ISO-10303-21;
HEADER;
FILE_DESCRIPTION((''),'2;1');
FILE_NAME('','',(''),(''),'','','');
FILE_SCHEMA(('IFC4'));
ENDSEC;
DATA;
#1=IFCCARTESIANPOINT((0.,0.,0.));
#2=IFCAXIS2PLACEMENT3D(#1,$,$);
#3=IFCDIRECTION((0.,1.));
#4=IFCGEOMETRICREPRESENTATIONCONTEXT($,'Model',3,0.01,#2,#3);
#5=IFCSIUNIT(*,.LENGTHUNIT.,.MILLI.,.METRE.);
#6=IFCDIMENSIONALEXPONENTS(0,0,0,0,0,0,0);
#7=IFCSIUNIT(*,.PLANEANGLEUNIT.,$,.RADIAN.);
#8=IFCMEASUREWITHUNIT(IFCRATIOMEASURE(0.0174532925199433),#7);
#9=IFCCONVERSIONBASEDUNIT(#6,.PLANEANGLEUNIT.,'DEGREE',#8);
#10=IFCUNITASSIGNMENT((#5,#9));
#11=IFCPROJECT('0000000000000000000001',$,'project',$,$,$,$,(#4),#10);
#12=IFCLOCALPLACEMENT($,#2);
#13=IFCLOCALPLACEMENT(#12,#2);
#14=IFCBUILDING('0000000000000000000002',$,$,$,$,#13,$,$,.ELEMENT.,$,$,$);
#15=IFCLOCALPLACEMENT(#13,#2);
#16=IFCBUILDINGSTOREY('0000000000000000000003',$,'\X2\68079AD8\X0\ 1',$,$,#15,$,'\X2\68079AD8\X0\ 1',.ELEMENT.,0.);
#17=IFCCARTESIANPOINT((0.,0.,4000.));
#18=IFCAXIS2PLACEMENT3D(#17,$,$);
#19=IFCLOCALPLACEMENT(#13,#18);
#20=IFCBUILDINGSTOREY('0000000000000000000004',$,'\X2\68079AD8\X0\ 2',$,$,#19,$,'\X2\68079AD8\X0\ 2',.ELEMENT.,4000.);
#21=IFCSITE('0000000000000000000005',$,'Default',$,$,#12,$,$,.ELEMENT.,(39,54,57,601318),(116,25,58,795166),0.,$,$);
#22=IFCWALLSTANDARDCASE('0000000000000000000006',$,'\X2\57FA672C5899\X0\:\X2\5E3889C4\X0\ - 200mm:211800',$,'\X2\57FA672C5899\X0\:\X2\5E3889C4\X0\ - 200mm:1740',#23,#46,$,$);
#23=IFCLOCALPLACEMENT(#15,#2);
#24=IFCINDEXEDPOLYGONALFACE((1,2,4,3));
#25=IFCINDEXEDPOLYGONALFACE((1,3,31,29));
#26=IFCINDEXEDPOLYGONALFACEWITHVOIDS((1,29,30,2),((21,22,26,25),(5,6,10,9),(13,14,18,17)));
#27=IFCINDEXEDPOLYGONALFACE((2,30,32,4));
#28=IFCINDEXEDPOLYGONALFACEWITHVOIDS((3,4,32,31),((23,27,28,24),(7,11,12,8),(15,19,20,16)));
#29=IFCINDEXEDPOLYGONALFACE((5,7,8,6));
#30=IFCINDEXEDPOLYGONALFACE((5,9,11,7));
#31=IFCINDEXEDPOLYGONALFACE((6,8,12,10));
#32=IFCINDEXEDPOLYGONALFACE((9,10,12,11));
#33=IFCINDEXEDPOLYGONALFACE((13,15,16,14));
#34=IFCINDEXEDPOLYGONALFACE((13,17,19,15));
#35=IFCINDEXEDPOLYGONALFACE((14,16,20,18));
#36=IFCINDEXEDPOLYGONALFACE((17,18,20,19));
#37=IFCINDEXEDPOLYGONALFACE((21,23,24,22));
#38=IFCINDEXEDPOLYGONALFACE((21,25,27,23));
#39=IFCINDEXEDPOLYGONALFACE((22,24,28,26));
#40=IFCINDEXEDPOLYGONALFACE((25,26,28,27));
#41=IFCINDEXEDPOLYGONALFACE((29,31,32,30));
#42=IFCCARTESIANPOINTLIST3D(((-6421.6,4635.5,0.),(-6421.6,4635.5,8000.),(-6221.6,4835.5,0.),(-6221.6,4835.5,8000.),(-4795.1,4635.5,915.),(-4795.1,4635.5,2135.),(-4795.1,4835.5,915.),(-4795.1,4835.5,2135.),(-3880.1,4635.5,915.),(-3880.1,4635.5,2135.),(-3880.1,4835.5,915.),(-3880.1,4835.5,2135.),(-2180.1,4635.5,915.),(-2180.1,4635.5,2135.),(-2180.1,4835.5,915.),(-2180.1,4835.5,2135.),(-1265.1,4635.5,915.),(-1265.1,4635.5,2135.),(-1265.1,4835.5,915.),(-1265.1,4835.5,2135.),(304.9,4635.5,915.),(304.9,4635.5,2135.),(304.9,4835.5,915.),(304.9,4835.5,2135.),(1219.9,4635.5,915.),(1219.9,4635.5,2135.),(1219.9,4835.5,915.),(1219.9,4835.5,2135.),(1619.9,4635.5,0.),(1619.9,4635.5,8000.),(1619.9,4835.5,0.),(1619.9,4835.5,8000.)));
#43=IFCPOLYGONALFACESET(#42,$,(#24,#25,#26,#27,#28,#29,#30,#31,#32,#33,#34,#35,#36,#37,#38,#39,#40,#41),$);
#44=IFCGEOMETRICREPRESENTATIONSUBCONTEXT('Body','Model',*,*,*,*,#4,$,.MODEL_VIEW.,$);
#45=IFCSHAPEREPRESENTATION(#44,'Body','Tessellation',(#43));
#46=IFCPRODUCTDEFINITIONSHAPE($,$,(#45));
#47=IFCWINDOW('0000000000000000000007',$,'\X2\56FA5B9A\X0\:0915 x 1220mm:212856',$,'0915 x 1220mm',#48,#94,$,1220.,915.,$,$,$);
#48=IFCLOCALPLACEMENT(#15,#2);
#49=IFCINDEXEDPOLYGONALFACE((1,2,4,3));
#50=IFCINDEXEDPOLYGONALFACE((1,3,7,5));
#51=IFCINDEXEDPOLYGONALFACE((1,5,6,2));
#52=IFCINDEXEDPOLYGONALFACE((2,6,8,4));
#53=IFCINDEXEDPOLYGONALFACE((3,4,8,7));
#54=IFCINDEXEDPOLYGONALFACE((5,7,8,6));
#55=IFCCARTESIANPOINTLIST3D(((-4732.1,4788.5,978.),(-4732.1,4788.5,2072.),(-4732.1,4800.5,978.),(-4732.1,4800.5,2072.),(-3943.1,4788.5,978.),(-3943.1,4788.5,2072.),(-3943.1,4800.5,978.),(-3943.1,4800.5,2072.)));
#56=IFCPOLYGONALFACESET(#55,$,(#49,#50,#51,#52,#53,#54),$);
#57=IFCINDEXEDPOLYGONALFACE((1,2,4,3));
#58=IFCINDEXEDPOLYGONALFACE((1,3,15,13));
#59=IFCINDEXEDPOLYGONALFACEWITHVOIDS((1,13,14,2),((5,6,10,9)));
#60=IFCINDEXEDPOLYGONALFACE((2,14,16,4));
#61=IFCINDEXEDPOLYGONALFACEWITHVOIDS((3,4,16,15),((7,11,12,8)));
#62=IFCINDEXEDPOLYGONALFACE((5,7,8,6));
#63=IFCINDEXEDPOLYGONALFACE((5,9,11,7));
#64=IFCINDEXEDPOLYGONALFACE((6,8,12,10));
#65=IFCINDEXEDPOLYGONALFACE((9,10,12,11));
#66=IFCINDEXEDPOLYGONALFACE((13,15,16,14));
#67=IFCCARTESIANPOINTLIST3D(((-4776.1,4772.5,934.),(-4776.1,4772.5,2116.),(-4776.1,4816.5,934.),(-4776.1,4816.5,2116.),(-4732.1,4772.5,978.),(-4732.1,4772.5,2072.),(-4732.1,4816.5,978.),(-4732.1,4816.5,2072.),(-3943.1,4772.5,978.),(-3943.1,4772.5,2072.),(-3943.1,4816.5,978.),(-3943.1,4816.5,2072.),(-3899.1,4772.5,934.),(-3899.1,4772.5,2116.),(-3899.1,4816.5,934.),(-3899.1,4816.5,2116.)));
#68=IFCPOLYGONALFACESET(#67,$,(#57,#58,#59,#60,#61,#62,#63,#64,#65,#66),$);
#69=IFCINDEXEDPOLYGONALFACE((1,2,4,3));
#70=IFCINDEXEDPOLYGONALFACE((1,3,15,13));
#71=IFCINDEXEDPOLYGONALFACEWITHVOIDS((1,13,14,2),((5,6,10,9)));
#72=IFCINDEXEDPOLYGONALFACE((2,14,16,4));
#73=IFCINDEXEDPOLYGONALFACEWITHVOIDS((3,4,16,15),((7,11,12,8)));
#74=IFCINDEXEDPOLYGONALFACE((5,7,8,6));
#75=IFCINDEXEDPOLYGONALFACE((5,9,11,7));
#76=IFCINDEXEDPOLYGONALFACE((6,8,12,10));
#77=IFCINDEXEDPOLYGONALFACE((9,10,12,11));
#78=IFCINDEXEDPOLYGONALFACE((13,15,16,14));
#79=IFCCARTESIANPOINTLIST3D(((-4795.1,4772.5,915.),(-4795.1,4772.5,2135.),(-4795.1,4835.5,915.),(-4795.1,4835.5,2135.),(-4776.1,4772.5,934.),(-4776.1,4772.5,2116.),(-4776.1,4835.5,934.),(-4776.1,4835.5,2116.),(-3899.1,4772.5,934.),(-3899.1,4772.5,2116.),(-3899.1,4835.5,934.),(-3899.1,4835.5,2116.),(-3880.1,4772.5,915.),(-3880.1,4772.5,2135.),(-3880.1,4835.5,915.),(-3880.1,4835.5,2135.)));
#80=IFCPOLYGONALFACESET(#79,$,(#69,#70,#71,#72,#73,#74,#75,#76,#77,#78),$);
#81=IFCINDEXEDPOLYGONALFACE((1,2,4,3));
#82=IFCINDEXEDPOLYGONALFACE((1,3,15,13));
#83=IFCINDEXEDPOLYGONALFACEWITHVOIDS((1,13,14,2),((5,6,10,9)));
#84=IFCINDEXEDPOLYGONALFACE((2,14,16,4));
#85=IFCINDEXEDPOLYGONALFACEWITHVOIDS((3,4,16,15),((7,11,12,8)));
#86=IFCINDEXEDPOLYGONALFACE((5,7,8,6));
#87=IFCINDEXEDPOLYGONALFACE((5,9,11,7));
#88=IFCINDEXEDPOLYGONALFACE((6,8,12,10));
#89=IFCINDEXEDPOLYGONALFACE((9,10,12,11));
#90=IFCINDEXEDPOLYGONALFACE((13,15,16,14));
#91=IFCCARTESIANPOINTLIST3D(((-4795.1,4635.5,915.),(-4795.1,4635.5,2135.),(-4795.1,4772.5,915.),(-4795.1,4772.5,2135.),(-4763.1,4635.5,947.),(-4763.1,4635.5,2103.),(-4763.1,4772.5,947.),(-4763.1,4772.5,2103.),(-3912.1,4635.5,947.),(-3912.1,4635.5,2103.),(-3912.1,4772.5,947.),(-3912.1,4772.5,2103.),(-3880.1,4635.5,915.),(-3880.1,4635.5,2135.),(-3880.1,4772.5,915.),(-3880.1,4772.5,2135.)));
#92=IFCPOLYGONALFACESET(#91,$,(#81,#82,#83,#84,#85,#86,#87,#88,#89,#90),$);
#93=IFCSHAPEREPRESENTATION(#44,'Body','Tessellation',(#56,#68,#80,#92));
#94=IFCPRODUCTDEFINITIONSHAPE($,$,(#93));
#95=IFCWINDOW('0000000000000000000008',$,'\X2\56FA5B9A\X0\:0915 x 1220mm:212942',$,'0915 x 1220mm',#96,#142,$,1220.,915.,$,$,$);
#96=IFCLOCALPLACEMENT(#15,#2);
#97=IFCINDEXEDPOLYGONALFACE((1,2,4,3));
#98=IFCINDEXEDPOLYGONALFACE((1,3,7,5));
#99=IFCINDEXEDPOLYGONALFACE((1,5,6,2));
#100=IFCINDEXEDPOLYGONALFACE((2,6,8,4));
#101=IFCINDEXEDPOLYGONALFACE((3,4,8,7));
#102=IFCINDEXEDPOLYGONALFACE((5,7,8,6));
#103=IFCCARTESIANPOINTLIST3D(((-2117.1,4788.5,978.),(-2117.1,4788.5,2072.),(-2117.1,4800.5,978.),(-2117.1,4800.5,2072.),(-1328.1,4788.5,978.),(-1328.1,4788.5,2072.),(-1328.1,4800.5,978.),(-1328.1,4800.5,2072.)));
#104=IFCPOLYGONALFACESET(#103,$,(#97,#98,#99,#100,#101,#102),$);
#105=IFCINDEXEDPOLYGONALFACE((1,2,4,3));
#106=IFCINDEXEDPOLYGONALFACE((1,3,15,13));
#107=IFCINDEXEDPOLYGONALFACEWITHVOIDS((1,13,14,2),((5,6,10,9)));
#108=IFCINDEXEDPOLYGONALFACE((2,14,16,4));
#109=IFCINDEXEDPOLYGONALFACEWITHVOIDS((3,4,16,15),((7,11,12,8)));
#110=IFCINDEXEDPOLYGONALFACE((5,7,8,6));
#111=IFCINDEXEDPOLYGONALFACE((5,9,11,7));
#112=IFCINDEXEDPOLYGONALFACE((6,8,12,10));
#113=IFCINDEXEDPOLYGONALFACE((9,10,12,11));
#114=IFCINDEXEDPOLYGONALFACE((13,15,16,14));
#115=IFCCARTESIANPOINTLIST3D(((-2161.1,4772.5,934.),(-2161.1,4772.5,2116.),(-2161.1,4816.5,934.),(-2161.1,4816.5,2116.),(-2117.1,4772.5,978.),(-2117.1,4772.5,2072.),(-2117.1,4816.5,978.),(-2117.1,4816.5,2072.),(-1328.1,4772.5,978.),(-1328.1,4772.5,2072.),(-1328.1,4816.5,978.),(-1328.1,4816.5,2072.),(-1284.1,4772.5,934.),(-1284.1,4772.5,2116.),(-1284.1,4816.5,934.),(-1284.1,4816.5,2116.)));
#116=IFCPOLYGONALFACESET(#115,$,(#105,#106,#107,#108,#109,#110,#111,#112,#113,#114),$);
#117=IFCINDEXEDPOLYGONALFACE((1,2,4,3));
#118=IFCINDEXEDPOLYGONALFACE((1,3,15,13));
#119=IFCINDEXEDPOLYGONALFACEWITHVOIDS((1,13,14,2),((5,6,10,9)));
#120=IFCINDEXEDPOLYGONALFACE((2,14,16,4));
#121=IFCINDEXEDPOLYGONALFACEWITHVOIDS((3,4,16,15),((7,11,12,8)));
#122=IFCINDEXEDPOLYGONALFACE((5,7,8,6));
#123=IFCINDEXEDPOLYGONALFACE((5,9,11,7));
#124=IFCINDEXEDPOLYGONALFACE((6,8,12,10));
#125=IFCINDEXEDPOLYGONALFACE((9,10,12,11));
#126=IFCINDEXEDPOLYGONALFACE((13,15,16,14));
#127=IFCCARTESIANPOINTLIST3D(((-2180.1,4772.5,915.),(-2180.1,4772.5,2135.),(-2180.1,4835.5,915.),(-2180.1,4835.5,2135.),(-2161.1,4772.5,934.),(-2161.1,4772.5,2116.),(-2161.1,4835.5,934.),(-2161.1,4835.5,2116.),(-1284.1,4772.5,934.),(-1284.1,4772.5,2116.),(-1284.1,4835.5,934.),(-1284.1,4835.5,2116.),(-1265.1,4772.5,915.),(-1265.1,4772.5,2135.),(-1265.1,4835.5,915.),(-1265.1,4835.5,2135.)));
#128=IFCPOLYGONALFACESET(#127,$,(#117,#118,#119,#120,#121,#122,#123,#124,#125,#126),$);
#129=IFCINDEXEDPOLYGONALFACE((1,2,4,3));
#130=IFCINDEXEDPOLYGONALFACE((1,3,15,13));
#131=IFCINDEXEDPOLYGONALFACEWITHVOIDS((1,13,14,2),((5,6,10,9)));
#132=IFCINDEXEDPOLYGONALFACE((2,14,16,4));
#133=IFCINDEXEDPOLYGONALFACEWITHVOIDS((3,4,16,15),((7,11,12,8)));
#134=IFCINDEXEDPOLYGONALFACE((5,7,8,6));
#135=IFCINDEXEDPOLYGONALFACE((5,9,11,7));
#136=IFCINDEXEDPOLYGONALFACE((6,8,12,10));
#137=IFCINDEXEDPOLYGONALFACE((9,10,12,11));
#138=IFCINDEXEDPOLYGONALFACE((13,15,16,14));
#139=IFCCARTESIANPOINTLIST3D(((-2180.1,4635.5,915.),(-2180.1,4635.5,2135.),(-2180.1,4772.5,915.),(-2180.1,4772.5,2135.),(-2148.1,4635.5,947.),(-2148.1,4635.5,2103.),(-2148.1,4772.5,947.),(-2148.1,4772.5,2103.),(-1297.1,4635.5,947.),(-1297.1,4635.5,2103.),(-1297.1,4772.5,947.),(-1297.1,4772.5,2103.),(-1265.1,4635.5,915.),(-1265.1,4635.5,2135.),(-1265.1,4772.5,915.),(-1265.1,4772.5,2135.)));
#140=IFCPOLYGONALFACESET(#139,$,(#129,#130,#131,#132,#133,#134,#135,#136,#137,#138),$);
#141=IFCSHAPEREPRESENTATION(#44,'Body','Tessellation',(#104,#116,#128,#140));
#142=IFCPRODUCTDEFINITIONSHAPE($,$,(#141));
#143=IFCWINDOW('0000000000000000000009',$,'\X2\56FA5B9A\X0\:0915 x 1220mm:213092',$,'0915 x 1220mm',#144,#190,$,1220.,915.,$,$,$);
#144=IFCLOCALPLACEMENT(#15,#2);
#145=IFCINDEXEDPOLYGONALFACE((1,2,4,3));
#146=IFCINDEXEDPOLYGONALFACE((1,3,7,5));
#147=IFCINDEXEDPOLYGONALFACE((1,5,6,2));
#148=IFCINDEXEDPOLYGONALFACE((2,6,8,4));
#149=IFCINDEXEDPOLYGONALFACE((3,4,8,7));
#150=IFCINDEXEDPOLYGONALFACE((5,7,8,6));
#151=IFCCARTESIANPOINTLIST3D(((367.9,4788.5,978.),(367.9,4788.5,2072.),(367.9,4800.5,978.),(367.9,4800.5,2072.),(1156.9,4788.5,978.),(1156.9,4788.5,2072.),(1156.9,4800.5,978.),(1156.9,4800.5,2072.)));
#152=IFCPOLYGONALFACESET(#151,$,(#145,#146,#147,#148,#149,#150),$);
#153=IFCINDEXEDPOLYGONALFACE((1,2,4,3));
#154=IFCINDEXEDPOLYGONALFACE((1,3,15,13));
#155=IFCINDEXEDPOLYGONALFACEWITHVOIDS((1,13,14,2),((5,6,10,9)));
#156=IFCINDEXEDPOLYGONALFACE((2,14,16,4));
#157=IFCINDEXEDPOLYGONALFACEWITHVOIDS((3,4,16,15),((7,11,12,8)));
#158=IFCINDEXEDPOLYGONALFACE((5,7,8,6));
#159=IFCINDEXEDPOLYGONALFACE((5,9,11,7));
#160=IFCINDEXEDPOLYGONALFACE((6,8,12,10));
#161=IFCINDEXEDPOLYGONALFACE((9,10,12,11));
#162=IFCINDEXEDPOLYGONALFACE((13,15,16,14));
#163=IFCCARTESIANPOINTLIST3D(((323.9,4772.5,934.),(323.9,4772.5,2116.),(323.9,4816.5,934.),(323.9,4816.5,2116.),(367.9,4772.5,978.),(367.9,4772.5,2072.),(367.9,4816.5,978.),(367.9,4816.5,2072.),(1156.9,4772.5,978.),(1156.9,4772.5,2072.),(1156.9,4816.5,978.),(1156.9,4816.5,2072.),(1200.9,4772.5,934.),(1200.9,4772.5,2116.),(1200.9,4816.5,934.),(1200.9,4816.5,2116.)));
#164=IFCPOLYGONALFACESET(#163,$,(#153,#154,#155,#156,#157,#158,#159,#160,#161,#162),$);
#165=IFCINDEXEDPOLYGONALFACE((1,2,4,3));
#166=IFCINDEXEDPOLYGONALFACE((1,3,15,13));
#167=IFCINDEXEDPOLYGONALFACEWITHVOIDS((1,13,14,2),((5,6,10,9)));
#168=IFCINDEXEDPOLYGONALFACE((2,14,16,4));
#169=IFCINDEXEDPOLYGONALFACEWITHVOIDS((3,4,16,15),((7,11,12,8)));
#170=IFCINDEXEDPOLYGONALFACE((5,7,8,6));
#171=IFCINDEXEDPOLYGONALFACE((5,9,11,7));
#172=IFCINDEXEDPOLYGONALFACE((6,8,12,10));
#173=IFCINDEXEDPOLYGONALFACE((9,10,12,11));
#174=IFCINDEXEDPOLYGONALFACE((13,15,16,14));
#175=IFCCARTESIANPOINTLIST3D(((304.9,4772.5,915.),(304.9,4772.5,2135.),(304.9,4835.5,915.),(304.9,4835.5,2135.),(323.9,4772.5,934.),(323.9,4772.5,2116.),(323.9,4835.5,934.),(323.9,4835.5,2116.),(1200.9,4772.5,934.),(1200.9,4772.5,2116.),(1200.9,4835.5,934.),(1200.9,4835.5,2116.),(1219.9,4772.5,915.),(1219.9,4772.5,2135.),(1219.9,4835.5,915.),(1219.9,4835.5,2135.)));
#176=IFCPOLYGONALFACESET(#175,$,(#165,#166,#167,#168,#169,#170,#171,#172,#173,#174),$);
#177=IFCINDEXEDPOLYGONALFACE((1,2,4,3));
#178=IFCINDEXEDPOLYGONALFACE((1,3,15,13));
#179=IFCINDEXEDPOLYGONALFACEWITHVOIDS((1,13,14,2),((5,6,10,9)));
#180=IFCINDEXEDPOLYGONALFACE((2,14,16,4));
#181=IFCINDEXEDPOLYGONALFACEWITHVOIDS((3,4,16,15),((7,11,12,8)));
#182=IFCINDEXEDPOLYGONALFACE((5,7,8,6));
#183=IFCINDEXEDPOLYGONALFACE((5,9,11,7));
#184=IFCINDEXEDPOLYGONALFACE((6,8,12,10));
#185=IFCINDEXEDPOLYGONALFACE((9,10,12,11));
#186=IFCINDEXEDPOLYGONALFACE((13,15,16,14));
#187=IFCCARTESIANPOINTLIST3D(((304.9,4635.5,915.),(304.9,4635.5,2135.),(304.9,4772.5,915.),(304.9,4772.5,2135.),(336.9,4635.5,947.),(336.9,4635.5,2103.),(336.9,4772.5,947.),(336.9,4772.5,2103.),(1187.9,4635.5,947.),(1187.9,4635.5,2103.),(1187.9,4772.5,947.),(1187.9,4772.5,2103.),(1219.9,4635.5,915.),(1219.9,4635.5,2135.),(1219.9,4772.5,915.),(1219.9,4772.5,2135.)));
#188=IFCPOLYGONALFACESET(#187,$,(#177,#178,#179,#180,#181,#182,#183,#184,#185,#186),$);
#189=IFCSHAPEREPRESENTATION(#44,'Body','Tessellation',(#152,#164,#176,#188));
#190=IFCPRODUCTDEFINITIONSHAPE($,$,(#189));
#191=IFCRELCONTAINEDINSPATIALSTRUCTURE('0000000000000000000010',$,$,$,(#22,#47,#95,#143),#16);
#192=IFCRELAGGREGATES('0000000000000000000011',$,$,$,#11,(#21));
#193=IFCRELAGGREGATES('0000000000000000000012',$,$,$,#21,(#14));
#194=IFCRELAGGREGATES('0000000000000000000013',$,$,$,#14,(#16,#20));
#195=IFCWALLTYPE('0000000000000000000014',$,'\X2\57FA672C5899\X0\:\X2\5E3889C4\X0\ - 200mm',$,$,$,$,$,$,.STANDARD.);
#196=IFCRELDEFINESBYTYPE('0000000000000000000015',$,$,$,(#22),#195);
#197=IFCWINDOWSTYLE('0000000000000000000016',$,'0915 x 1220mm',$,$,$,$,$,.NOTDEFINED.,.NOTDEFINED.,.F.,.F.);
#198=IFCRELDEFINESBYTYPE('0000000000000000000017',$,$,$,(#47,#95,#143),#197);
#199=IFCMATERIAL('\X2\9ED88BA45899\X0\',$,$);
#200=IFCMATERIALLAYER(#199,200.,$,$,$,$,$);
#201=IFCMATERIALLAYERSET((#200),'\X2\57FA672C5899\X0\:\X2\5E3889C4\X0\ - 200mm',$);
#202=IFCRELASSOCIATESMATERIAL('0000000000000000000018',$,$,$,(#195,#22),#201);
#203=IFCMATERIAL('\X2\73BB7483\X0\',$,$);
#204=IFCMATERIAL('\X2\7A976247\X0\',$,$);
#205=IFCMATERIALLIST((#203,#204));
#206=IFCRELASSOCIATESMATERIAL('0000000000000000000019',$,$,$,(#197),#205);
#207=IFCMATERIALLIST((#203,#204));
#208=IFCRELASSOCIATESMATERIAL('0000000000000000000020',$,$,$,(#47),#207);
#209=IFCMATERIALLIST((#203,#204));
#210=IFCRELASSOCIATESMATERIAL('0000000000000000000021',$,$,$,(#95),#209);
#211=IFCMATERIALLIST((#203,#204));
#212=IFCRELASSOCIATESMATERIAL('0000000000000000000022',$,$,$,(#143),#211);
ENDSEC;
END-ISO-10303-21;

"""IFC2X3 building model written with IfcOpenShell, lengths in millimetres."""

from ifc_helpers import new_model, entity, si_unit, converted_unit, direction, frame, frame_2d, origin, place, context, subcontext, project, spatial, polyline, rectangle, outline, extrude, source, transform, mapped, material, material_list, layer, layer_set, layer_usage, type_object, type_shapes, element, fill, save


model = new_model("IFC2X3")

# Units and contexts
model_context = context("Model", 3, precision=0.01, world=origin(), true_north=direction((0.0, 1.0)))
body_context = subcontext(model_context, "Body", "Model", "MODEL_VIEW")
ifc_project = project(units=[si_unit("LENGTHUNIT", "METRE", prefix="MILLI"), converted_unit("PLANEANGLEUNIT", "DEGREE", entity("IfcRatioMeasure", 0.0174532925199433), si_unit("PLANEANGLEUNIT", "RADIAN"), dimensions=[0, 0, 0, 0, 0, 0, 0])], contexts=[model_context])

# Site, building, storey
site_placement = place(None, origin())
site = spatial("IfcSite", under=ifc_project, at=site_placement, Name="Default", CompositionType="ELEMENT", RefLatitude=(39, 54, 57, 601318), RefLongitude=(116, 25, 58, 795166), RefElevation=0.0)
building_placement = place(site_placement, origin())
building = spatial("IfcBuilding", under=site, at=building_placement, CompositionType="ELEMENT")
storey_1_placement = place(building_placement, origin())
storey_1 = spatial("IfcBuildingStorey", under=building, at=storey_1_placement, Name="标高 1", LongName="标高 1", CompositionType="ELEMENT", Elevation=0.0)

# Wall, openings, windows
ifc_material_1 = material(Name="默认墙")
ifc_layer_1 = layer(ifc_material_1, 200.0)
ifc_layer_set_1 = layer_set([ifc_layer_1], Name="基本墙:常规 - 200mm")
ifc_layer_usage_1 = layer_usage(ifc_layer_set_1, "AXIS2", "NEGATIVE", 100.0)
wall_type_1 = type_object("IfcWallType", Name="基本墙:常规 - 200mm", PredefinedType="STANDARD", material=ifc_layer_set_1)
wall_1_placement = place(storey_1_placement, frame((-6421.6, 4735.5, 0.0)))
wall_1 = element("IfcWallStandardCase", 1, at=wall_1_placement, inside=storey_1, type_object=wall_type_1, material=ifc_layer_usage_1, Name="基本墙:常规 - 200mm:211800", ObjectType="基本墙:常规 - 200mm:1740", context=body_context, shape_type="SweptSolid", body=[
    extrude(outline(polyline([(8041.4, -100.0), (8041.4, 100.0), (200.0, 100.0), (0.0, -100.0), (282.8, -100.0), (7841.4, -100.0), (8041.4, -100.0)])), origin(), (0.0, 0.0, 1.0), 8000.0),
])
opening_1_placement = place(wall_1_placement, frame((1626.4, -100.0, 915.0)))
opening_1 = element("IfcOpeningElement", 2, at=opening_1_placement, cuts=wall_1, ObjectType="Opening", context=body_context, shape_type="SweptSolid", body=[
    extrude(rectangle(XDim=1220.0, YDim=915.0, at=frame_2d((610.0, 457.5), x_axis=(1.0, 0.0))), frame((0.0, 0.0, 0.0), z_axis=(0.0, 1.0, 0.0), x_axis=(0.0, 0.0, 1.0)), (0.0, 0.0, 1.0), 200.0),
])
opening_2_placement = place(wall_1_placement, frame((4241.4, -100.0, 915.0)))
opening_2 = element("IfcOpeningElement", 3, at=opening_2_placement, cuts=wall_1, ObjectType="Opening", context=body_context, shape_type="SweptSolid", body=[
    extrude(rectangle(XDim=1220.0, YDim=915.0, at=frame_2d((610.0, 457.5), x_axis=(1.0, 0.0))), frame((0.0, 0.0, 0.0), z_axis=(0.0, 1.0, 0.0), x_axis=(0.0, 0.0, 1.0)), (0.0, 0.0, 1.0), 200.0),
])
opening_3_placement = place(wall_1_placement, frame((6726.4, -100.0, 915.0)))
opening_3 = element("IfcOpeningElement", 4, at=opening_3_placement, cuts=wall_1, ObjectType="Opening", context=body_context, shape_type="SweptSolid", body=[
    extrude(rectangle(XDim=1220.0, YDim=915.0, at=frame_2d((610.0, 457.5), x_axis=(1.0, 0.0))), frame((0.0, 0.0, 0.0), z_axis=(0.0, 1.0, 0.0), x_axis=(0.0, 0.0, 1.0)), (0.0, 0.0, 1.0), 200.0),
])
ifc_material_2 = material(Name="玻璃")
ifc_material_3 = material(Name="窗扇")
ifc_material_list_1 = material_list([ifc_material_2, ifc_material_3])
ifc_material_list_2 = material_list([ifc_material_2, ifc_material_3])
window_style = type_object("IfcWindowStyle", Name="0915 x 1220mm", ConstructionType="NOTDEFINED", OperationType="NOTDEFINED", ParameterTakesPrecedence=False, Sizeable=False, material=ifc_material_list_2)
shared_shape_1 = source(origin(), body_context, "Body", "SweptSolid", [
    extrude(rectangle(XDim=12.0, YDim=789.0, at=frame_2d((0.0, 0.0), x_axis=(1.0, 0.0))), frame((457.5, 159.0, 63.0), z_axis=(0.0, 0.0, 1.0), x_axis=(0.0, -1.0, 0.0)), (0.0, 0.0, 1.0), 1094.0),
    extrude(outline(polyline([(-438.5, -591.0), (438.5, -591.0), (438.5, 591.0), (-438.5, 591.0), (-438.5, -591.0)]), holes=[polyline([(-394.5, -547.0), (-394.5, 547.0), (394.5, 547.0), (394.5, -547.0), (-394.5, -547.0)])]), frame((457.5, 137.0, 610.0), z_axis=(0.0, 1.0, 0.0), x_axis=(1.0, 0.0, 0.0)), (0.0, 0.0, 1.0), 44.0),
    extrude(outline(polyline([(-457.5, -610.0), (457.5, -610.0), (457.5, 610.0), (-457.5, 610.0), (-457.5, -610.0)]), holes=[polyline([(-438.5, -591.0), (-438.5, 591.0), (438.5, 591.0), (438.5, -591.0), (-438.5, -591.0)])]), frame((457.5, 137.0, 610.0), z_axis=(0.0, 1.0, 0.0), x_axis=(1.0, 0.0, 0.0)), (0.0, 0.0, 1.0), 63.0),
    extrude(outline(polyline([(-457.5, -610.0), (457.5, -610.0), (457.5, 610.0), (-457.5, 610.0), (-457.5, -610.0)]), holes=[polyline([(-425.5, -578.0), (-425.5, 578.0), (425.5, 578.0), (425.5, -578.0), (-425.5, -578.0)])]), frame((457.5, 0.0, 610.0), z_axis=(0.0, 1.0, 0.0), x_axis=(1.0, 0.0, 0.0)), (0.0, 0.0, 1.0), 137.0),
])
type_shapes(window_style, [shared_shape_1])
window_1_placement = place(opening_1_placement, origin())
window_1 = element("IfcWindow", 5, at=window_1_placement, inside=storey_1, type_object=window_style, material=ifc_material_list_1, Name="固定:0915 x 1220mm:212856", ObjectType="0915 x 1220mm", OverallHeight=1220.0, OverallWidth=915.0, context=body_context, shape_type="MappedRepresentation", body=[
    mapped(shared_shape_1, transform((0.0, 0.0, 0.0), scale=1.0)),
])
fill(opening_1, window_1)
ifc_material_list_3 = material_list([ifc_material_2, ifc_material_3])
window_2_placement = place(opening_2_placement, origin())
window_2 = element("IfcWindow", 6, at=window_2_placement, inside=storey_1, type_object=window_style, material=ifc_material_list_3, Name="固定:0915 x 1220mm:212942", ObjectType="0915 x 1220mm", OverallHeight=1220.0, OverallWidth=915.0, context=body_context, shape_type="MappedRepresentation", body=[
    mapped(shared_shape_1, transform((0.0, 0.0, 0.0), scale=1.0)),
])
fill(opening_2, window_2)
ifc_material_list_4 = material_list([ifc_material_2, ifc_material_3])
window_3_placement = place(opening_3_placement, origin())
window_3 = element("IfcWindow", 7, at=window_3_placement, inside=storey_1, type_object=window_style, material=ifc_material_list_4, Name="固定:0915 x 1220mm:213092", ObjectType="0915 x 1220mm", OverallHeight=1220.0, OverallWidth=915.0, context=body_context, shape_type="MappedRepresentation", body=[
    mapped(shared_shape_1, transform((0.0, 0.0, 0.0), scale=1.0)),
])
fill(opening_3, window_3)

# Shared definitions
storey_2_placement = place(building_placement, frame((0.0, 0.0, 4000.0)))
storey_2 = spatial("IfcBuildingStorey", under=building, at=storey_2_placement, Name="标高 2", LongName="标高 2", CompositionType="ELEMENT", Elevation=4000.0)

save(model, "model.ifc")
